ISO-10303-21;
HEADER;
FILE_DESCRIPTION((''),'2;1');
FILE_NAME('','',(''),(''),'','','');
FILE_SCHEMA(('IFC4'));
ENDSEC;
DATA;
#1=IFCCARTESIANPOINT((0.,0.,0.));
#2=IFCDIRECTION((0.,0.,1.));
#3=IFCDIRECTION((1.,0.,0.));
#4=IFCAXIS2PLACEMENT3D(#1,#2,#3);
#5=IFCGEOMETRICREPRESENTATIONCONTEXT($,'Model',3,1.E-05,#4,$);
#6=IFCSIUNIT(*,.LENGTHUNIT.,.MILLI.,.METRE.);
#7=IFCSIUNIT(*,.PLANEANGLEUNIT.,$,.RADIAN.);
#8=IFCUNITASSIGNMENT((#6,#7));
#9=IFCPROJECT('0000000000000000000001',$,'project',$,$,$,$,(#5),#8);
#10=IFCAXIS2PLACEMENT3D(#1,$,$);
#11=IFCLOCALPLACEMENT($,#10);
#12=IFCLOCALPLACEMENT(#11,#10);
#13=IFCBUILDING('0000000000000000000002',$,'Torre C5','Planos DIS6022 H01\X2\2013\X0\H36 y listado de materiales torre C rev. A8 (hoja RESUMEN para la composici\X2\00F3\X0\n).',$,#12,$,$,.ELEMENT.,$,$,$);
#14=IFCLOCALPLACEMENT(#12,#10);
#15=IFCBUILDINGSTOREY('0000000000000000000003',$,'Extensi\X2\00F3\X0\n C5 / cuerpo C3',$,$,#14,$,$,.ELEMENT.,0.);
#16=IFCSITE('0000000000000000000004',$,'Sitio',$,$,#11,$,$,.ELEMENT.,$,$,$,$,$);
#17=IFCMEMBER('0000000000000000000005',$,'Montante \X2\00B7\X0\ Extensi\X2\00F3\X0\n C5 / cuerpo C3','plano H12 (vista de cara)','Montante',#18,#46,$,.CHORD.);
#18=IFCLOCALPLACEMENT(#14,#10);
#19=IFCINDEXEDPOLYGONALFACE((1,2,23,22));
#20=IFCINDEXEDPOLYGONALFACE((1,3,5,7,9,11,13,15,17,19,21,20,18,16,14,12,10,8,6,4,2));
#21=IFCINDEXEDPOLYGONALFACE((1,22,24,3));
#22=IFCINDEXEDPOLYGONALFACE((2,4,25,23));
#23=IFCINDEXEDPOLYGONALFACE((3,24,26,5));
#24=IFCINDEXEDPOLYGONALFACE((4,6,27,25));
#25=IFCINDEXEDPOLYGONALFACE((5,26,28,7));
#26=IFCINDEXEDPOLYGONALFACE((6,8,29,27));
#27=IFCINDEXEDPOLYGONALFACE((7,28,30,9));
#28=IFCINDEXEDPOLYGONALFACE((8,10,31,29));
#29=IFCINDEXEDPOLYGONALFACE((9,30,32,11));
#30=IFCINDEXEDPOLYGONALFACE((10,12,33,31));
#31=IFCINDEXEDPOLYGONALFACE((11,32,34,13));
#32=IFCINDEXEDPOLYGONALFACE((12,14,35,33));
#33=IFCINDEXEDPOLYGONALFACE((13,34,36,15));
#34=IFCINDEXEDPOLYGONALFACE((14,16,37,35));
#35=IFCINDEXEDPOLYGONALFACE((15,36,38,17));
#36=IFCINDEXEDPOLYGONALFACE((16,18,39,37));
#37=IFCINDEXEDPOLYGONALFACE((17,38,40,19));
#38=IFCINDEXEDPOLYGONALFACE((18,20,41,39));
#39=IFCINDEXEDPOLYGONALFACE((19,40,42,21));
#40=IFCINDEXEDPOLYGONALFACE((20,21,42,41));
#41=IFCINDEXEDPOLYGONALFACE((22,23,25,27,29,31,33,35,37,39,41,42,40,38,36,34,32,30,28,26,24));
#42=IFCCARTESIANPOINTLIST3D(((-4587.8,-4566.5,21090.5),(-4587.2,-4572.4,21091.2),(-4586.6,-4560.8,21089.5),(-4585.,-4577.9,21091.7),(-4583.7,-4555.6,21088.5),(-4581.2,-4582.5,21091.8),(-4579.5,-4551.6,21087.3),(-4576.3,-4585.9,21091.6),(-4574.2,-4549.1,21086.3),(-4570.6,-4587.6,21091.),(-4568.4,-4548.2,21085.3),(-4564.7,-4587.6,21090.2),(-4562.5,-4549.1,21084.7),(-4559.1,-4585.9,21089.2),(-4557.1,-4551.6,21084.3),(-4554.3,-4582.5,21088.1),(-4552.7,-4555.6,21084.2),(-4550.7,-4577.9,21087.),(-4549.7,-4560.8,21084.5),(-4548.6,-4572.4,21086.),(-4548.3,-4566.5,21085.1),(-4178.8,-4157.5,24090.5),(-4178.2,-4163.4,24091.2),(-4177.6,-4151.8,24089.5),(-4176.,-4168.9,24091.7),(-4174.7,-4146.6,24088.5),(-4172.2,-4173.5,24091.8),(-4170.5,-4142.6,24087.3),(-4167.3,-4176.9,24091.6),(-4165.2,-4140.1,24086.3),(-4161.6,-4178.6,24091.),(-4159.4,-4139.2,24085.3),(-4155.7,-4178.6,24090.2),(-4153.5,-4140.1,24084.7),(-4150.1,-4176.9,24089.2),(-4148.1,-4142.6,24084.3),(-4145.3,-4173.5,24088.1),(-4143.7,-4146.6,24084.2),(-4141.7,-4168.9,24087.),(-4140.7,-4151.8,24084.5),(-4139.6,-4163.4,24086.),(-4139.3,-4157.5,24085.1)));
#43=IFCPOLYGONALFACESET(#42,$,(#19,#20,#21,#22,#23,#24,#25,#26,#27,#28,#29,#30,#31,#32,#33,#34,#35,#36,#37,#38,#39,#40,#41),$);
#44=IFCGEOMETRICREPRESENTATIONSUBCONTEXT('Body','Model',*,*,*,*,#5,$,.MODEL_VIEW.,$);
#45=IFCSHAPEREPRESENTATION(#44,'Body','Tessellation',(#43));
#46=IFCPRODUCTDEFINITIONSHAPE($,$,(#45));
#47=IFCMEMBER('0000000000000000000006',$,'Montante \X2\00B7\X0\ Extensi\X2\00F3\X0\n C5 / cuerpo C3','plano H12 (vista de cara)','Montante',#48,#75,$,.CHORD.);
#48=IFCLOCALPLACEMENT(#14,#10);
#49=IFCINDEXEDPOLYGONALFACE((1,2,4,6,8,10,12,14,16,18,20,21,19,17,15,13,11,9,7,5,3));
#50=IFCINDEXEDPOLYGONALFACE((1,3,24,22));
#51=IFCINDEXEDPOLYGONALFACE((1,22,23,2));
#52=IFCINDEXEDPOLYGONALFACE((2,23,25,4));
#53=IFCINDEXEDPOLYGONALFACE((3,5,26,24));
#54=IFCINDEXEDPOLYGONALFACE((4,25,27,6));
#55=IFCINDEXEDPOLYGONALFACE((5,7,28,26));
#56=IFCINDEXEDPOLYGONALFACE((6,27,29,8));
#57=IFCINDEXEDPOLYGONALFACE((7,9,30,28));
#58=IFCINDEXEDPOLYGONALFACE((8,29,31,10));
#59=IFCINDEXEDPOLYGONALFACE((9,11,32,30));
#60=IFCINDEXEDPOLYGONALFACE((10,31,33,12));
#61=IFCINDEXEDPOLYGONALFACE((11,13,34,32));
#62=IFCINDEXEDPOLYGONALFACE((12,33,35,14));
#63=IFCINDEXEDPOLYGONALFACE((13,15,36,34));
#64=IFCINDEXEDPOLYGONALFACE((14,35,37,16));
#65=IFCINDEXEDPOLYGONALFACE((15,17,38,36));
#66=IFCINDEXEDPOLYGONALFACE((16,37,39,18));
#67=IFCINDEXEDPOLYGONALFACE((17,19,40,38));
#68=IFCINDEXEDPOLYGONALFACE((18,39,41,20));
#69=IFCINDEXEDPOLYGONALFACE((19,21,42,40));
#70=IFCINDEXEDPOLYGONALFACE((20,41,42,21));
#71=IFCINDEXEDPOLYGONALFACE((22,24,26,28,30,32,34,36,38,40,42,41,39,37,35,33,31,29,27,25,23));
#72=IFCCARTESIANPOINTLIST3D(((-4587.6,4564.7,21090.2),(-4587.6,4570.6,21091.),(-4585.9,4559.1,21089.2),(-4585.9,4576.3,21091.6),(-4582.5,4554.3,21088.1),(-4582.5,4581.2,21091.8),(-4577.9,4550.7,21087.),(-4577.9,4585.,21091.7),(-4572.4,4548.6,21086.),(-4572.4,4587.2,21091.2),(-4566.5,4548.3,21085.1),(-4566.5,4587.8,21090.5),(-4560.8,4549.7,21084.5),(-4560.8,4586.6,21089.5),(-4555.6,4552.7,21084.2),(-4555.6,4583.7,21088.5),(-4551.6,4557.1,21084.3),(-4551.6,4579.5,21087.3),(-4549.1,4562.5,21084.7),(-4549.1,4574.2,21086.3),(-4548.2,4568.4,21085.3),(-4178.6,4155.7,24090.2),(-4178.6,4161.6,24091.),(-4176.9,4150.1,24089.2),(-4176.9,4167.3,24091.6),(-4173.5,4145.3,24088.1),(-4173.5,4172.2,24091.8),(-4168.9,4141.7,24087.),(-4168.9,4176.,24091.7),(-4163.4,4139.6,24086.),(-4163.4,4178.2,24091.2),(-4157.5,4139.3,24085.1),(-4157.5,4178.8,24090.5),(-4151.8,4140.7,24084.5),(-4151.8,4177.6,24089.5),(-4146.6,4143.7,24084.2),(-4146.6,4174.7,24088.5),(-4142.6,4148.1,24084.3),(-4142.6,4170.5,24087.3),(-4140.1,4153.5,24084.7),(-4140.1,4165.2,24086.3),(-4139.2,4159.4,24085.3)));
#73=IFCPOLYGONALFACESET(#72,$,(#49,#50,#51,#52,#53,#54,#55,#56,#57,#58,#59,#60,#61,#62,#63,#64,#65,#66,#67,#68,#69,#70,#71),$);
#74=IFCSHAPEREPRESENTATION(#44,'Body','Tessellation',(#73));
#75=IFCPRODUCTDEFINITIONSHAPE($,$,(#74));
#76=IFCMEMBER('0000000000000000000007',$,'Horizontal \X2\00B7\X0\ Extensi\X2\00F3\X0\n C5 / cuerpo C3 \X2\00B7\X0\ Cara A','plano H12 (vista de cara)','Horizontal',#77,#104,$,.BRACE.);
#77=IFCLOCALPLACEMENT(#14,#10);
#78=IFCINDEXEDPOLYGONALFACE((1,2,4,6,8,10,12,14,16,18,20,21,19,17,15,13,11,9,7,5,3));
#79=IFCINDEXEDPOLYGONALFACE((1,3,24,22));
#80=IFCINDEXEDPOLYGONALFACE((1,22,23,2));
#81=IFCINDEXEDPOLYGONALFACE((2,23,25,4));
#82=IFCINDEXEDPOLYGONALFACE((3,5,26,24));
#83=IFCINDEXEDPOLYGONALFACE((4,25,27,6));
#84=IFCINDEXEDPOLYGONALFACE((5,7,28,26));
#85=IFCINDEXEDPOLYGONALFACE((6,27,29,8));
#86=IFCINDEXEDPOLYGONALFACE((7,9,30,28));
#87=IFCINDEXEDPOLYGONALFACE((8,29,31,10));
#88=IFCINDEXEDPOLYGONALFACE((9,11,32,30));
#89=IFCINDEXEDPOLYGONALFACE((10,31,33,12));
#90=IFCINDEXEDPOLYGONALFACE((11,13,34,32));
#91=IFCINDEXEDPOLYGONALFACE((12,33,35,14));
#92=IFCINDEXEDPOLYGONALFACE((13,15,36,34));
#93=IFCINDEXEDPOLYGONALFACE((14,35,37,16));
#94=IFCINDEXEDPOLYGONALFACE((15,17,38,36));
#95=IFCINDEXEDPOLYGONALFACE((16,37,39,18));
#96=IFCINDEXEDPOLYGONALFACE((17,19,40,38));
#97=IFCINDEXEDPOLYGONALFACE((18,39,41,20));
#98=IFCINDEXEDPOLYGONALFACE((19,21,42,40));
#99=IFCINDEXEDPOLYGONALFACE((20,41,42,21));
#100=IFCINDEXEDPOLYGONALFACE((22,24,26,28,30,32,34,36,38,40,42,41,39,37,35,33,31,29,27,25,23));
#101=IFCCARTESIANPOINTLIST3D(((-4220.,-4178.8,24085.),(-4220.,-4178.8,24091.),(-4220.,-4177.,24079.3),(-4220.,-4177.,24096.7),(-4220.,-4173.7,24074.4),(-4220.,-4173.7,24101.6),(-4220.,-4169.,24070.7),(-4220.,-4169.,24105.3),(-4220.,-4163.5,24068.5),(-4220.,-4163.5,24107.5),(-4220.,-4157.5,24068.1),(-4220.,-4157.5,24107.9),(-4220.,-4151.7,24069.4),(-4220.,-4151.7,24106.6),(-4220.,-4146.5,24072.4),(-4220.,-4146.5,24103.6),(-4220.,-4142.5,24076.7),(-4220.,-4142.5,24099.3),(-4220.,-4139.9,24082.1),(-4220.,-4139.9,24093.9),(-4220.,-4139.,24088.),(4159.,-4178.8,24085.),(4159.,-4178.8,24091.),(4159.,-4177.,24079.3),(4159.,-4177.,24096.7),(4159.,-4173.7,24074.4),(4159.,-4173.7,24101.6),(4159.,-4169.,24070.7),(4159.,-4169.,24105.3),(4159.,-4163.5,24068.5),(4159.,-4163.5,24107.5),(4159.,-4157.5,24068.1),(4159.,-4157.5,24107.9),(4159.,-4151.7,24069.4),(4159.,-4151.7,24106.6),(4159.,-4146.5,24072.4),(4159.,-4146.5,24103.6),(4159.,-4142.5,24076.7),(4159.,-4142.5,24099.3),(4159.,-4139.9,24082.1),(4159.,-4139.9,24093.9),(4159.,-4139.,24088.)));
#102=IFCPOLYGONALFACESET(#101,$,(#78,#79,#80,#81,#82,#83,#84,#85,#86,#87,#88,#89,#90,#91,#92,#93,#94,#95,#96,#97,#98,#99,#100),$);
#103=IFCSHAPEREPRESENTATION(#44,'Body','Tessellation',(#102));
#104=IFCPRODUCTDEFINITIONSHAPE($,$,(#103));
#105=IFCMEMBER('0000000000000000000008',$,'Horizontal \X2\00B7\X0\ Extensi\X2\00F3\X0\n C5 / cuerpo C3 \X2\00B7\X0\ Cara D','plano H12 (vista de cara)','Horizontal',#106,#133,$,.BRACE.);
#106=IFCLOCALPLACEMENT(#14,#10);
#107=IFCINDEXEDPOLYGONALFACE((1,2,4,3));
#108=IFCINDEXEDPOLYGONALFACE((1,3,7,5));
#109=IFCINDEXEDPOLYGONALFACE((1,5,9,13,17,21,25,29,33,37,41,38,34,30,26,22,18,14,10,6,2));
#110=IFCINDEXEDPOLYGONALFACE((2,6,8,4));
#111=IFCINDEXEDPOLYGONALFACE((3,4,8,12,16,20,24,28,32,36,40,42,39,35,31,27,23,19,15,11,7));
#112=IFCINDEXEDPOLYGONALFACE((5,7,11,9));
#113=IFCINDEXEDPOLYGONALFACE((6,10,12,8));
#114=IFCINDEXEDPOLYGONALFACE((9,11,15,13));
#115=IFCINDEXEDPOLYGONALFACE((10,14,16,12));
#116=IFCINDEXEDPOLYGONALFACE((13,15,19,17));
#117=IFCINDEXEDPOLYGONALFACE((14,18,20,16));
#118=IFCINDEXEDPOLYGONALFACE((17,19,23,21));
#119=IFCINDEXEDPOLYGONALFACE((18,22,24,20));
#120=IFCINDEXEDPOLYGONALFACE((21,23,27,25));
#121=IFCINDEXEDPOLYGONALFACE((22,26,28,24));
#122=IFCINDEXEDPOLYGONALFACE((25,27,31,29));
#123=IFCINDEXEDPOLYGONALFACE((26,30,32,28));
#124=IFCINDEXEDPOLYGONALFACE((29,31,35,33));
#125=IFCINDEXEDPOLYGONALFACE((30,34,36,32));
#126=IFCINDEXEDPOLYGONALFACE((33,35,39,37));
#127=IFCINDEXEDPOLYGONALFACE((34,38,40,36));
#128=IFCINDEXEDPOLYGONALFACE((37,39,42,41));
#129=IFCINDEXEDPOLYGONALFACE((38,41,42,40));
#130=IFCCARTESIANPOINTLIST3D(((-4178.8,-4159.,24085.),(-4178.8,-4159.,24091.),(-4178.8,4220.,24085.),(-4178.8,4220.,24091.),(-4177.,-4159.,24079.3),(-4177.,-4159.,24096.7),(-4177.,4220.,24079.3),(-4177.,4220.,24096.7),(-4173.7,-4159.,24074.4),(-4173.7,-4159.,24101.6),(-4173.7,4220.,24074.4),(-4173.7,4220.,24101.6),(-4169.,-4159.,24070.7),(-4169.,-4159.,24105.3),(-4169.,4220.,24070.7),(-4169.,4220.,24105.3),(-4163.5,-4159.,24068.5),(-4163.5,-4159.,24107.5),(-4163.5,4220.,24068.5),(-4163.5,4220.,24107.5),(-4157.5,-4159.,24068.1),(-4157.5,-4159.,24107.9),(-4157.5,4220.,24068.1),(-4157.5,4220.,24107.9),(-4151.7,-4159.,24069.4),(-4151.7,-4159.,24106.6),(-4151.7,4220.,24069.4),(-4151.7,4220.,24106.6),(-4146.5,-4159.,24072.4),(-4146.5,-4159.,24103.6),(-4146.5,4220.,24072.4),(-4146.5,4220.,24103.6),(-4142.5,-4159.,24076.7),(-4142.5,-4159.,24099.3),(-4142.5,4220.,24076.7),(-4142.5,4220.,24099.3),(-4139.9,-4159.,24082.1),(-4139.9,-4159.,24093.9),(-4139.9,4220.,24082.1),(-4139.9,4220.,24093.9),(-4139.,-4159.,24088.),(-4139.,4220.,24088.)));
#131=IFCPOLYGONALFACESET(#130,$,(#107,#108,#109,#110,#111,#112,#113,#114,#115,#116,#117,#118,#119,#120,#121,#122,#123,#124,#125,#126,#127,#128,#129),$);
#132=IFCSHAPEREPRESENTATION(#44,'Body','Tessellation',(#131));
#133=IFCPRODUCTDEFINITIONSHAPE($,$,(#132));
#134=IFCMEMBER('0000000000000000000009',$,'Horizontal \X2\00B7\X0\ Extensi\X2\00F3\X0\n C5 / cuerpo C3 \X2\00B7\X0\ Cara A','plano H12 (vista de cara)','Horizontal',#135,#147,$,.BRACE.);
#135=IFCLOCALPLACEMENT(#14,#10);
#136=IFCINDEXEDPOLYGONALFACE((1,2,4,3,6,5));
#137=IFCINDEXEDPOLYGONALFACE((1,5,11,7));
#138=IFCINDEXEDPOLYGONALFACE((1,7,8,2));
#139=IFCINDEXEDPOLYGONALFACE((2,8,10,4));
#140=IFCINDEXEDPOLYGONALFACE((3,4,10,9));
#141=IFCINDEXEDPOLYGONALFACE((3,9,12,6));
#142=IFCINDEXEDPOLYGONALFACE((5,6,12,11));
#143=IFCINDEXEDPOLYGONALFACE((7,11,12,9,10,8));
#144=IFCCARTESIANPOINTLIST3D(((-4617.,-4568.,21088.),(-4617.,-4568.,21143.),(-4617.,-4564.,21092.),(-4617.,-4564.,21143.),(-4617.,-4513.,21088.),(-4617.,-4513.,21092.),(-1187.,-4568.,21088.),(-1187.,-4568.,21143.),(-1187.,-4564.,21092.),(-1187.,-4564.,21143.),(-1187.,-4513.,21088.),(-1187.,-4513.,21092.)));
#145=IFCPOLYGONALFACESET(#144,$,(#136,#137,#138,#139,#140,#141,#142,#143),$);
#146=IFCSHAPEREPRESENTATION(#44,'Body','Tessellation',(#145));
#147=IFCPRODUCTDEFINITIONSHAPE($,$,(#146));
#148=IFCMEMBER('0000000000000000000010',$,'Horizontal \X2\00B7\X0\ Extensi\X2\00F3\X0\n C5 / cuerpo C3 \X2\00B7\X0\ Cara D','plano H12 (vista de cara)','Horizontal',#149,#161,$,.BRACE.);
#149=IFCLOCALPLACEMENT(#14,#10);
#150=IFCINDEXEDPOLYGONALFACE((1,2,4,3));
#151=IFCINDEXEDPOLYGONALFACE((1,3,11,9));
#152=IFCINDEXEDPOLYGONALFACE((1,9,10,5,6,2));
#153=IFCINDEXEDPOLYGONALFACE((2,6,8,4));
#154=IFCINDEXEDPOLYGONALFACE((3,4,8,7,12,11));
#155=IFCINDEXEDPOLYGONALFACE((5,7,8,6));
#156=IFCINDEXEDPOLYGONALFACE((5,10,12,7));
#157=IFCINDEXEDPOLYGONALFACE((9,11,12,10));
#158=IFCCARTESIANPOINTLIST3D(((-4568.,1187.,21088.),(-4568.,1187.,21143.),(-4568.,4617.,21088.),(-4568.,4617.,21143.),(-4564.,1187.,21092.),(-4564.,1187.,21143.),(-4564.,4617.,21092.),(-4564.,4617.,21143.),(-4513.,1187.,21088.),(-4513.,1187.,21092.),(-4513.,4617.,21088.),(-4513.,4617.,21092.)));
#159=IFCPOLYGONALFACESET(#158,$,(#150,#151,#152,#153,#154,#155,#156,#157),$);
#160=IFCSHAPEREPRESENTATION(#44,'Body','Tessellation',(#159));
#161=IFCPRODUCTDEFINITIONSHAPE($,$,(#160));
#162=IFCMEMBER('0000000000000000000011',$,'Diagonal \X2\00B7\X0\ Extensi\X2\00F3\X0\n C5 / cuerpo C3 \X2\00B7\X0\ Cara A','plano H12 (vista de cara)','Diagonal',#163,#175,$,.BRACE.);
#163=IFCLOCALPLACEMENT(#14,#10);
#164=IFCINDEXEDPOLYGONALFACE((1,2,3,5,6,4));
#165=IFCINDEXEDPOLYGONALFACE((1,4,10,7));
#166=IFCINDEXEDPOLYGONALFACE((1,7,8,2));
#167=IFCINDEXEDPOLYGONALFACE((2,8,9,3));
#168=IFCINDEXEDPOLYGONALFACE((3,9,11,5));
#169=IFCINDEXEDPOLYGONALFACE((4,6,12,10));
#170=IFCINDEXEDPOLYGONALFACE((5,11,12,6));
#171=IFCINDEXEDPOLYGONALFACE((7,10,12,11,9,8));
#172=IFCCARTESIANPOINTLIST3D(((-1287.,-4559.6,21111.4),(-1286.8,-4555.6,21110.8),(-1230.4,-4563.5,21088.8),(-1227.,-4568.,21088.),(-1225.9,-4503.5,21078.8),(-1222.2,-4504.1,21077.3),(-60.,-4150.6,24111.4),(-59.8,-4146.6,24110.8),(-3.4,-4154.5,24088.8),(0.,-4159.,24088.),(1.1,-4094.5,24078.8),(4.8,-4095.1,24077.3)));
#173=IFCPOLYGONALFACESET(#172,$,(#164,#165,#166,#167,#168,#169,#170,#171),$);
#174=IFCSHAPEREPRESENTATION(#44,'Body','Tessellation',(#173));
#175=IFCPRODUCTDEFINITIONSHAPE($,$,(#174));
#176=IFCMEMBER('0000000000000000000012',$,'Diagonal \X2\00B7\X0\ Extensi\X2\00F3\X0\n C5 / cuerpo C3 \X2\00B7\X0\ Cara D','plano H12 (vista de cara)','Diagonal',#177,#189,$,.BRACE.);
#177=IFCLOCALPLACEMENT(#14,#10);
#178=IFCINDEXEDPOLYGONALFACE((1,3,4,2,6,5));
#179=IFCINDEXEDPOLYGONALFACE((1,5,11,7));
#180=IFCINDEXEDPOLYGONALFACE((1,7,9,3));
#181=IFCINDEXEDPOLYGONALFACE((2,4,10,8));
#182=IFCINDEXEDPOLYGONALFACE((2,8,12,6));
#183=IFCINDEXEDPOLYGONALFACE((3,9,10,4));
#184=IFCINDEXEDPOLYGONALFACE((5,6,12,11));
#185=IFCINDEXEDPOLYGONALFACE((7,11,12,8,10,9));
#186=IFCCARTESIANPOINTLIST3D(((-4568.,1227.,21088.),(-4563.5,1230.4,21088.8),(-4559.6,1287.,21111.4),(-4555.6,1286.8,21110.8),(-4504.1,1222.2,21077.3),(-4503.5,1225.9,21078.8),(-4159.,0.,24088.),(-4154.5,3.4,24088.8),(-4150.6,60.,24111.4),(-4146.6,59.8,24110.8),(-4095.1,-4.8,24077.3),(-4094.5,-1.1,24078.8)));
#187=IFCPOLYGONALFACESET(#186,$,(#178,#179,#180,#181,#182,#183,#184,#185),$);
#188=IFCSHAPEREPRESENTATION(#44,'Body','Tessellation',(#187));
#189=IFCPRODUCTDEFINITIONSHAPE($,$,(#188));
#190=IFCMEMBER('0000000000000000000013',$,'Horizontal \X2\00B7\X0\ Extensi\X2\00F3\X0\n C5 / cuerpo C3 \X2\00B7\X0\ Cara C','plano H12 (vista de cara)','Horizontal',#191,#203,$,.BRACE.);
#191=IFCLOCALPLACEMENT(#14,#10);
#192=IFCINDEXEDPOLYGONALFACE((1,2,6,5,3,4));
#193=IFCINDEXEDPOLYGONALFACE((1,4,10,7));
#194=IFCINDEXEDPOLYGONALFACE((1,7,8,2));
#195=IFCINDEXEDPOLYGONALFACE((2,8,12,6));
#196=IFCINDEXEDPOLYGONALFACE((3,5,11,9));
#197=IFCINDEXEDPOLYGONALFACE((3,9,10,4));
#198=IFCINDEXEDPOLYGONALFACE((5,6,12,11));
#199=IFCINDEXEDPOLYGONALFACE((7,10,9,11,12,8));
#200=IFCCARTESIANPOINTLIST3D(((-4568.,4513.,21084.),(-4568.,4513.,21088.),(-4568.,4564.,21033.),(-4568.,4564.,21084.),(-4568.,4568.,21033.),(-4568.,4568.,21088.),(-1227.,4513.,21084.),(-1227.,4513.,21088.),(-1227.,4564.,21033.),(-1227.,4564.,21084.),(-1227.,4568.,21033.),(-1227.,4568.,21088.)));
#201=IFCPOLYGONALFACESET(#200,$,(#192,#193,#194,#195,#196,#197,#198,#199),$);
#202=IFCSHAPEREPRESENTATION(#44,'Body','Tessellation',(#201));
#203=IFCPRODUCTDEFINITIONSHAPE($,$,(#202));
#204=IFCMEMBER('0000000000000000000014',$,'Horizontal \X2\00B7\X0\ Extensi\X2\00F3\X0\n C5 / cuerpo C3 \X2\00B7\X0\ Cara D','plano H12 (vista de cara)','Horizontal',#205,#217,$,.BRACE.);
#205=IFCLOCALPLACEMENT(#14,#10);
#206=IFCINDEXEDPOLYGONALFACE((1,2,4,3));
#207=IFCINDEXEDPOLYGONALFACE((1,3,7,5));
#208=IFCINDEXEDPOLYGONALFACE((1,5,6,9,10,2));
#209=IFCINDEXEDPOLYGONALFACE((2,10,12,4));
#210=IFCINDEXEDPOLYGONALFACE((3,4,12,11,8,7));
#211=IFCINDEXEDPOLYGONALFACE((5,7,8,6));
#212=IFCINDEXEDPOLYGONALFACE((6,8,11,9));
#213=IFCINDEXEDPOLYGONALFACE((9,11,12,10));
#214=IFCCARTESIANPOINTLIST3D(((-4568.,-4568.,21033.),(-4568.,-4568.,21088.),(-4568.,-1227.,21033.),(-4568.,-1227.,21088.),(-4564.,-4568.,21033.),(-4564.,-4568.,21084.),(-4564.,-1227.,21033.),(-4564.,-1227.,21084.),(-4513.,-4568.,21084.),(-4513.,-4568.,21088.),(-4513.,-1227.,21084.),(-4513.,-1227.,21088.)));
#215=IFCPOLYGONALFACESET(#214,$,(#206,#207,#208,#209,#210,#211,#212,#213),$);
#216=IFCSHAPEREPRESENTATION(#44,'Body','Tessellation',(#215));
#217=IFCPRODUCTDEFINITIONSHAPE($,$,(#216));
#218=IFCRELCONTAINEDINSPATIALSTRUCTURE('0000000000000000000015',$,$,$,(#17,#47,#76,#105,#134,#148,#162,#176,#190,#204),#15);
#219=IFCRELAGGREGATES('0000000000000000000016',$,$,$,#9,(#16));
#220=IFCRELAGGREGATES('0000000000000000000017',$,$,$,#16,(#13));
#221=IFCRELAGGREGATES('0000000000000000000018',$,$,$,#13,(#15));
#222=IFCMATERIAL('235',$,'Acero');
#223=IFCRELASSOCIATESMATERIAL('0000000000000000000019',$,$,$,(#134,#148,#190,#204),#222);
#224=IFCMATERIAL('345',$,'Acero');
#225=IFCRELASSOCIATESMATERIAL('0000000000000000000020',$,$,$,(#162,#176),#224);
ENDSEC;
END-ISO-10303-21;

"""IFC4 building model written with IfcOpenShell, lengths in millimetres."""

from ifc_helpers import new_model, si_unit, frame, frame_2d, origin, origin_with_axes, place, context, subcontext, project, spatial, circle, l_section, extrude, material, element, save


model = new_model("IFC4")

# Units and contexts
model_context = context("Model", 3, precision=1e-05, world=origin_with_axes())
body_context = subcontext(model_context, "Body", "Model", "MODEL_VIEW")
ifc_project = project(units=[si_unit("LENGTHUNIT", "METRE", prefix="MILLI"), si_unit("PLANEANGLEUNIT", "RADIAN")], contexts=[model_context])

# Site, building, storey
site_placement = place(None, origin())
site = spatial("IfcSite", under=ifc_project, at=site_placement, Name="Sitio", CompositionType="ELEMENT")
building_placement = place(site_placement, origin())
building = spatial("IfcBuilding", under=site, at=building_placement, Name="Torre C5", Description="Planos DIS6022 H01–H36 y listado de materiales torre C rev. A8 (hoja RESUMEN para la composición).", CompositionType="ELEMENT")
storey_placement = place(building_placement, origin())
storey = spatial("IfcBuildingStorey", under=building, at=storey_placement, Name="Extensión C5 / cuerpo C3", CompositionType="ELEMENT", Elevation=0.0)

# Members
for number, where, z_axis, x_axis, name in (
    (1, (-4159.0, -4159.0, 24088.0), (-0.133868, -0.133868, -0.981916), (-0.018083, 0.990999, -0.132641), "Montante · Extensión C5 / cuerpo C3"),
    (2, (-4159.0, 4159.0, 24088.0), (-0.133868, 0.133868, -0.981916), (0.990999, 0.018083, -0.132641), "Montante · Extensión C5 / cuerpo C3"),
):
    element("IfcMember", number, at=place(storey_placement, frame(where, z_axis=z_axis, x_axis=x_axis)), inside=storey, Name=name, Description="plano H12 (vista de cara)", ObjectType="Montante", PredefinedType="CHORD", context=body_context, shape_type="SweptSolid", body=[
        extrude(circle(Radius=20.0), None, (0.0, 0.0, 1.0), 3055.3),
    ])
for number, where, z_axis, x_axis, name in (
    (3, (-4220.0, -4159.0, 24088.0), (1.0, 0.0, 0.0), (0.0, 1.0, 0.0), "Horizontal · Extensión C5 / cuerpo C3 · Cara A"),
    (4, (-4159.0, 4220.0, 24088.0), (0.0, -1.0, 0.0), (1.0, 0.0, 0.0), "Horizontal · Extensión C5 / cuerpo C3 · Cara D"),
):
    element("IfcMember", number, at=place(storey_placement, frame(where, z_axis=z_axis, x_axis=x_axis)), inside=storey, Name=name, Description="plano H12 (vista de cara)", ObjectType="Horizontal", PredefinedType="BRACE", context=body_context, shape_type="SweptSolid", body=[
        extrude(circle(Radius=20.0), None, (0.0, 0.0, 1.0), 8379.0),
    ])
ifc_material_1 = material(Name="235", Category="Acero")
for number, where, z_axis, x_axis, name in (
    (5, (-4617.0, -4568.0, 21088.0), (1.0, 0.0, 0.0), (0.0, 1.0, 0.0), "Horizontal · Extensión C5 / cuerpo C3 · Cara A"),
    (6, (-4568.0, 4617.0, 21088.0), (0.0, -1.0, 0.0), (1.0, 0.0, 0.0), "Horizontal · Extensión C5 / cuerpo C3 · Cara D"),
):
    element("IfcMember", number, at=place(storey_placement, frame(where, z_axis=z_axis, x_axis=x_axis)), inside=storey, material=ifc_material_1, Name=name, Description="plano H12 (vista de cara)", ObjectType="Horizontal", PredefinedType="BRACE", context=body_context, shape_type="SweptSolid", body=[
        extrude(l_section(Depth=55.0, Width=55.0, Thickness=4.0, at=frame_2d((27.5, 27.5))), None, (0.0, 0.0, 1.0), 3430.0),
    ])
ifc_material_2 = material(Name="345", Category="Acero")
for number, where, z_axis, x_axis, name in (
    (7, (-1227.0, -4568.0, 21088.0), (0.375582, 0.125194, 0.918294), (0.074188, 0.983593, -0.164439), "Diagonal · Extensión C5 / cuerpo C3 · Cara A"),
    (8, (-4568.0, 1227.0, 21088.0), (0.125194, -0.375582, 0.918294), (0.983593, -0.074188, -0.164439), "Diagonal · Extensión C5 / cuerpo C3 · Cara D"),
):
    element("IfcMember", number, at=place(storey_placement, frame(where, z_axis=z_axis, x_axis=x_axis)), inside=storey, material=ifc_material_2, Name=name, Description="plano H12 (vista de cara)", ObjectType="Diagonal", PredefinedType="BRACE", context=body_context, shape_type="SweptSolid", body=[
        extrude(l_section(Depth=65.0, Width=65.0, Thickness=4.0, at=frame_2d((32.5, 32.5))), None, (0.0, 0.0, 1.0), 3266.9),
    ])
for number, where, z_axis, x_axis, name in (
    (9, (-4568.0, 4568.0, 21088.0), (1.0, 0.0, 0.0), (0.0, -1.0, 0.0), "Horizontal · Extensión C5 / cuerpo C3 · Cara C"),
    (10, (-4568.0, -4568.0, 21088.0), (0.0, 1.0, 0.0), (1.0, 0.0, 0.0), "Horizontal · Extensión C5 / cuerpo C3 · Cara D"),
):
    element("IfcMember", number, at=place(storey_placement, frame(where, z_axis=z_axis, x_axis=x_axis)), inside=storey, material=ifc_material_1, Name=name, Description="plano H12 (vista de cara)", ObjectType="Horizontal", PredefinedType="BRACE", context=body_context, shape_type="SweptSolid", body=[
        extrude(l_section(Depth=55.0, Width=55.0, Thickness=4.0, at=frame_2d((27.5, 27.5))), None, (0.0, 0.0, 1.0), 3341.0),
    ])

save(model, "model.ifc")
